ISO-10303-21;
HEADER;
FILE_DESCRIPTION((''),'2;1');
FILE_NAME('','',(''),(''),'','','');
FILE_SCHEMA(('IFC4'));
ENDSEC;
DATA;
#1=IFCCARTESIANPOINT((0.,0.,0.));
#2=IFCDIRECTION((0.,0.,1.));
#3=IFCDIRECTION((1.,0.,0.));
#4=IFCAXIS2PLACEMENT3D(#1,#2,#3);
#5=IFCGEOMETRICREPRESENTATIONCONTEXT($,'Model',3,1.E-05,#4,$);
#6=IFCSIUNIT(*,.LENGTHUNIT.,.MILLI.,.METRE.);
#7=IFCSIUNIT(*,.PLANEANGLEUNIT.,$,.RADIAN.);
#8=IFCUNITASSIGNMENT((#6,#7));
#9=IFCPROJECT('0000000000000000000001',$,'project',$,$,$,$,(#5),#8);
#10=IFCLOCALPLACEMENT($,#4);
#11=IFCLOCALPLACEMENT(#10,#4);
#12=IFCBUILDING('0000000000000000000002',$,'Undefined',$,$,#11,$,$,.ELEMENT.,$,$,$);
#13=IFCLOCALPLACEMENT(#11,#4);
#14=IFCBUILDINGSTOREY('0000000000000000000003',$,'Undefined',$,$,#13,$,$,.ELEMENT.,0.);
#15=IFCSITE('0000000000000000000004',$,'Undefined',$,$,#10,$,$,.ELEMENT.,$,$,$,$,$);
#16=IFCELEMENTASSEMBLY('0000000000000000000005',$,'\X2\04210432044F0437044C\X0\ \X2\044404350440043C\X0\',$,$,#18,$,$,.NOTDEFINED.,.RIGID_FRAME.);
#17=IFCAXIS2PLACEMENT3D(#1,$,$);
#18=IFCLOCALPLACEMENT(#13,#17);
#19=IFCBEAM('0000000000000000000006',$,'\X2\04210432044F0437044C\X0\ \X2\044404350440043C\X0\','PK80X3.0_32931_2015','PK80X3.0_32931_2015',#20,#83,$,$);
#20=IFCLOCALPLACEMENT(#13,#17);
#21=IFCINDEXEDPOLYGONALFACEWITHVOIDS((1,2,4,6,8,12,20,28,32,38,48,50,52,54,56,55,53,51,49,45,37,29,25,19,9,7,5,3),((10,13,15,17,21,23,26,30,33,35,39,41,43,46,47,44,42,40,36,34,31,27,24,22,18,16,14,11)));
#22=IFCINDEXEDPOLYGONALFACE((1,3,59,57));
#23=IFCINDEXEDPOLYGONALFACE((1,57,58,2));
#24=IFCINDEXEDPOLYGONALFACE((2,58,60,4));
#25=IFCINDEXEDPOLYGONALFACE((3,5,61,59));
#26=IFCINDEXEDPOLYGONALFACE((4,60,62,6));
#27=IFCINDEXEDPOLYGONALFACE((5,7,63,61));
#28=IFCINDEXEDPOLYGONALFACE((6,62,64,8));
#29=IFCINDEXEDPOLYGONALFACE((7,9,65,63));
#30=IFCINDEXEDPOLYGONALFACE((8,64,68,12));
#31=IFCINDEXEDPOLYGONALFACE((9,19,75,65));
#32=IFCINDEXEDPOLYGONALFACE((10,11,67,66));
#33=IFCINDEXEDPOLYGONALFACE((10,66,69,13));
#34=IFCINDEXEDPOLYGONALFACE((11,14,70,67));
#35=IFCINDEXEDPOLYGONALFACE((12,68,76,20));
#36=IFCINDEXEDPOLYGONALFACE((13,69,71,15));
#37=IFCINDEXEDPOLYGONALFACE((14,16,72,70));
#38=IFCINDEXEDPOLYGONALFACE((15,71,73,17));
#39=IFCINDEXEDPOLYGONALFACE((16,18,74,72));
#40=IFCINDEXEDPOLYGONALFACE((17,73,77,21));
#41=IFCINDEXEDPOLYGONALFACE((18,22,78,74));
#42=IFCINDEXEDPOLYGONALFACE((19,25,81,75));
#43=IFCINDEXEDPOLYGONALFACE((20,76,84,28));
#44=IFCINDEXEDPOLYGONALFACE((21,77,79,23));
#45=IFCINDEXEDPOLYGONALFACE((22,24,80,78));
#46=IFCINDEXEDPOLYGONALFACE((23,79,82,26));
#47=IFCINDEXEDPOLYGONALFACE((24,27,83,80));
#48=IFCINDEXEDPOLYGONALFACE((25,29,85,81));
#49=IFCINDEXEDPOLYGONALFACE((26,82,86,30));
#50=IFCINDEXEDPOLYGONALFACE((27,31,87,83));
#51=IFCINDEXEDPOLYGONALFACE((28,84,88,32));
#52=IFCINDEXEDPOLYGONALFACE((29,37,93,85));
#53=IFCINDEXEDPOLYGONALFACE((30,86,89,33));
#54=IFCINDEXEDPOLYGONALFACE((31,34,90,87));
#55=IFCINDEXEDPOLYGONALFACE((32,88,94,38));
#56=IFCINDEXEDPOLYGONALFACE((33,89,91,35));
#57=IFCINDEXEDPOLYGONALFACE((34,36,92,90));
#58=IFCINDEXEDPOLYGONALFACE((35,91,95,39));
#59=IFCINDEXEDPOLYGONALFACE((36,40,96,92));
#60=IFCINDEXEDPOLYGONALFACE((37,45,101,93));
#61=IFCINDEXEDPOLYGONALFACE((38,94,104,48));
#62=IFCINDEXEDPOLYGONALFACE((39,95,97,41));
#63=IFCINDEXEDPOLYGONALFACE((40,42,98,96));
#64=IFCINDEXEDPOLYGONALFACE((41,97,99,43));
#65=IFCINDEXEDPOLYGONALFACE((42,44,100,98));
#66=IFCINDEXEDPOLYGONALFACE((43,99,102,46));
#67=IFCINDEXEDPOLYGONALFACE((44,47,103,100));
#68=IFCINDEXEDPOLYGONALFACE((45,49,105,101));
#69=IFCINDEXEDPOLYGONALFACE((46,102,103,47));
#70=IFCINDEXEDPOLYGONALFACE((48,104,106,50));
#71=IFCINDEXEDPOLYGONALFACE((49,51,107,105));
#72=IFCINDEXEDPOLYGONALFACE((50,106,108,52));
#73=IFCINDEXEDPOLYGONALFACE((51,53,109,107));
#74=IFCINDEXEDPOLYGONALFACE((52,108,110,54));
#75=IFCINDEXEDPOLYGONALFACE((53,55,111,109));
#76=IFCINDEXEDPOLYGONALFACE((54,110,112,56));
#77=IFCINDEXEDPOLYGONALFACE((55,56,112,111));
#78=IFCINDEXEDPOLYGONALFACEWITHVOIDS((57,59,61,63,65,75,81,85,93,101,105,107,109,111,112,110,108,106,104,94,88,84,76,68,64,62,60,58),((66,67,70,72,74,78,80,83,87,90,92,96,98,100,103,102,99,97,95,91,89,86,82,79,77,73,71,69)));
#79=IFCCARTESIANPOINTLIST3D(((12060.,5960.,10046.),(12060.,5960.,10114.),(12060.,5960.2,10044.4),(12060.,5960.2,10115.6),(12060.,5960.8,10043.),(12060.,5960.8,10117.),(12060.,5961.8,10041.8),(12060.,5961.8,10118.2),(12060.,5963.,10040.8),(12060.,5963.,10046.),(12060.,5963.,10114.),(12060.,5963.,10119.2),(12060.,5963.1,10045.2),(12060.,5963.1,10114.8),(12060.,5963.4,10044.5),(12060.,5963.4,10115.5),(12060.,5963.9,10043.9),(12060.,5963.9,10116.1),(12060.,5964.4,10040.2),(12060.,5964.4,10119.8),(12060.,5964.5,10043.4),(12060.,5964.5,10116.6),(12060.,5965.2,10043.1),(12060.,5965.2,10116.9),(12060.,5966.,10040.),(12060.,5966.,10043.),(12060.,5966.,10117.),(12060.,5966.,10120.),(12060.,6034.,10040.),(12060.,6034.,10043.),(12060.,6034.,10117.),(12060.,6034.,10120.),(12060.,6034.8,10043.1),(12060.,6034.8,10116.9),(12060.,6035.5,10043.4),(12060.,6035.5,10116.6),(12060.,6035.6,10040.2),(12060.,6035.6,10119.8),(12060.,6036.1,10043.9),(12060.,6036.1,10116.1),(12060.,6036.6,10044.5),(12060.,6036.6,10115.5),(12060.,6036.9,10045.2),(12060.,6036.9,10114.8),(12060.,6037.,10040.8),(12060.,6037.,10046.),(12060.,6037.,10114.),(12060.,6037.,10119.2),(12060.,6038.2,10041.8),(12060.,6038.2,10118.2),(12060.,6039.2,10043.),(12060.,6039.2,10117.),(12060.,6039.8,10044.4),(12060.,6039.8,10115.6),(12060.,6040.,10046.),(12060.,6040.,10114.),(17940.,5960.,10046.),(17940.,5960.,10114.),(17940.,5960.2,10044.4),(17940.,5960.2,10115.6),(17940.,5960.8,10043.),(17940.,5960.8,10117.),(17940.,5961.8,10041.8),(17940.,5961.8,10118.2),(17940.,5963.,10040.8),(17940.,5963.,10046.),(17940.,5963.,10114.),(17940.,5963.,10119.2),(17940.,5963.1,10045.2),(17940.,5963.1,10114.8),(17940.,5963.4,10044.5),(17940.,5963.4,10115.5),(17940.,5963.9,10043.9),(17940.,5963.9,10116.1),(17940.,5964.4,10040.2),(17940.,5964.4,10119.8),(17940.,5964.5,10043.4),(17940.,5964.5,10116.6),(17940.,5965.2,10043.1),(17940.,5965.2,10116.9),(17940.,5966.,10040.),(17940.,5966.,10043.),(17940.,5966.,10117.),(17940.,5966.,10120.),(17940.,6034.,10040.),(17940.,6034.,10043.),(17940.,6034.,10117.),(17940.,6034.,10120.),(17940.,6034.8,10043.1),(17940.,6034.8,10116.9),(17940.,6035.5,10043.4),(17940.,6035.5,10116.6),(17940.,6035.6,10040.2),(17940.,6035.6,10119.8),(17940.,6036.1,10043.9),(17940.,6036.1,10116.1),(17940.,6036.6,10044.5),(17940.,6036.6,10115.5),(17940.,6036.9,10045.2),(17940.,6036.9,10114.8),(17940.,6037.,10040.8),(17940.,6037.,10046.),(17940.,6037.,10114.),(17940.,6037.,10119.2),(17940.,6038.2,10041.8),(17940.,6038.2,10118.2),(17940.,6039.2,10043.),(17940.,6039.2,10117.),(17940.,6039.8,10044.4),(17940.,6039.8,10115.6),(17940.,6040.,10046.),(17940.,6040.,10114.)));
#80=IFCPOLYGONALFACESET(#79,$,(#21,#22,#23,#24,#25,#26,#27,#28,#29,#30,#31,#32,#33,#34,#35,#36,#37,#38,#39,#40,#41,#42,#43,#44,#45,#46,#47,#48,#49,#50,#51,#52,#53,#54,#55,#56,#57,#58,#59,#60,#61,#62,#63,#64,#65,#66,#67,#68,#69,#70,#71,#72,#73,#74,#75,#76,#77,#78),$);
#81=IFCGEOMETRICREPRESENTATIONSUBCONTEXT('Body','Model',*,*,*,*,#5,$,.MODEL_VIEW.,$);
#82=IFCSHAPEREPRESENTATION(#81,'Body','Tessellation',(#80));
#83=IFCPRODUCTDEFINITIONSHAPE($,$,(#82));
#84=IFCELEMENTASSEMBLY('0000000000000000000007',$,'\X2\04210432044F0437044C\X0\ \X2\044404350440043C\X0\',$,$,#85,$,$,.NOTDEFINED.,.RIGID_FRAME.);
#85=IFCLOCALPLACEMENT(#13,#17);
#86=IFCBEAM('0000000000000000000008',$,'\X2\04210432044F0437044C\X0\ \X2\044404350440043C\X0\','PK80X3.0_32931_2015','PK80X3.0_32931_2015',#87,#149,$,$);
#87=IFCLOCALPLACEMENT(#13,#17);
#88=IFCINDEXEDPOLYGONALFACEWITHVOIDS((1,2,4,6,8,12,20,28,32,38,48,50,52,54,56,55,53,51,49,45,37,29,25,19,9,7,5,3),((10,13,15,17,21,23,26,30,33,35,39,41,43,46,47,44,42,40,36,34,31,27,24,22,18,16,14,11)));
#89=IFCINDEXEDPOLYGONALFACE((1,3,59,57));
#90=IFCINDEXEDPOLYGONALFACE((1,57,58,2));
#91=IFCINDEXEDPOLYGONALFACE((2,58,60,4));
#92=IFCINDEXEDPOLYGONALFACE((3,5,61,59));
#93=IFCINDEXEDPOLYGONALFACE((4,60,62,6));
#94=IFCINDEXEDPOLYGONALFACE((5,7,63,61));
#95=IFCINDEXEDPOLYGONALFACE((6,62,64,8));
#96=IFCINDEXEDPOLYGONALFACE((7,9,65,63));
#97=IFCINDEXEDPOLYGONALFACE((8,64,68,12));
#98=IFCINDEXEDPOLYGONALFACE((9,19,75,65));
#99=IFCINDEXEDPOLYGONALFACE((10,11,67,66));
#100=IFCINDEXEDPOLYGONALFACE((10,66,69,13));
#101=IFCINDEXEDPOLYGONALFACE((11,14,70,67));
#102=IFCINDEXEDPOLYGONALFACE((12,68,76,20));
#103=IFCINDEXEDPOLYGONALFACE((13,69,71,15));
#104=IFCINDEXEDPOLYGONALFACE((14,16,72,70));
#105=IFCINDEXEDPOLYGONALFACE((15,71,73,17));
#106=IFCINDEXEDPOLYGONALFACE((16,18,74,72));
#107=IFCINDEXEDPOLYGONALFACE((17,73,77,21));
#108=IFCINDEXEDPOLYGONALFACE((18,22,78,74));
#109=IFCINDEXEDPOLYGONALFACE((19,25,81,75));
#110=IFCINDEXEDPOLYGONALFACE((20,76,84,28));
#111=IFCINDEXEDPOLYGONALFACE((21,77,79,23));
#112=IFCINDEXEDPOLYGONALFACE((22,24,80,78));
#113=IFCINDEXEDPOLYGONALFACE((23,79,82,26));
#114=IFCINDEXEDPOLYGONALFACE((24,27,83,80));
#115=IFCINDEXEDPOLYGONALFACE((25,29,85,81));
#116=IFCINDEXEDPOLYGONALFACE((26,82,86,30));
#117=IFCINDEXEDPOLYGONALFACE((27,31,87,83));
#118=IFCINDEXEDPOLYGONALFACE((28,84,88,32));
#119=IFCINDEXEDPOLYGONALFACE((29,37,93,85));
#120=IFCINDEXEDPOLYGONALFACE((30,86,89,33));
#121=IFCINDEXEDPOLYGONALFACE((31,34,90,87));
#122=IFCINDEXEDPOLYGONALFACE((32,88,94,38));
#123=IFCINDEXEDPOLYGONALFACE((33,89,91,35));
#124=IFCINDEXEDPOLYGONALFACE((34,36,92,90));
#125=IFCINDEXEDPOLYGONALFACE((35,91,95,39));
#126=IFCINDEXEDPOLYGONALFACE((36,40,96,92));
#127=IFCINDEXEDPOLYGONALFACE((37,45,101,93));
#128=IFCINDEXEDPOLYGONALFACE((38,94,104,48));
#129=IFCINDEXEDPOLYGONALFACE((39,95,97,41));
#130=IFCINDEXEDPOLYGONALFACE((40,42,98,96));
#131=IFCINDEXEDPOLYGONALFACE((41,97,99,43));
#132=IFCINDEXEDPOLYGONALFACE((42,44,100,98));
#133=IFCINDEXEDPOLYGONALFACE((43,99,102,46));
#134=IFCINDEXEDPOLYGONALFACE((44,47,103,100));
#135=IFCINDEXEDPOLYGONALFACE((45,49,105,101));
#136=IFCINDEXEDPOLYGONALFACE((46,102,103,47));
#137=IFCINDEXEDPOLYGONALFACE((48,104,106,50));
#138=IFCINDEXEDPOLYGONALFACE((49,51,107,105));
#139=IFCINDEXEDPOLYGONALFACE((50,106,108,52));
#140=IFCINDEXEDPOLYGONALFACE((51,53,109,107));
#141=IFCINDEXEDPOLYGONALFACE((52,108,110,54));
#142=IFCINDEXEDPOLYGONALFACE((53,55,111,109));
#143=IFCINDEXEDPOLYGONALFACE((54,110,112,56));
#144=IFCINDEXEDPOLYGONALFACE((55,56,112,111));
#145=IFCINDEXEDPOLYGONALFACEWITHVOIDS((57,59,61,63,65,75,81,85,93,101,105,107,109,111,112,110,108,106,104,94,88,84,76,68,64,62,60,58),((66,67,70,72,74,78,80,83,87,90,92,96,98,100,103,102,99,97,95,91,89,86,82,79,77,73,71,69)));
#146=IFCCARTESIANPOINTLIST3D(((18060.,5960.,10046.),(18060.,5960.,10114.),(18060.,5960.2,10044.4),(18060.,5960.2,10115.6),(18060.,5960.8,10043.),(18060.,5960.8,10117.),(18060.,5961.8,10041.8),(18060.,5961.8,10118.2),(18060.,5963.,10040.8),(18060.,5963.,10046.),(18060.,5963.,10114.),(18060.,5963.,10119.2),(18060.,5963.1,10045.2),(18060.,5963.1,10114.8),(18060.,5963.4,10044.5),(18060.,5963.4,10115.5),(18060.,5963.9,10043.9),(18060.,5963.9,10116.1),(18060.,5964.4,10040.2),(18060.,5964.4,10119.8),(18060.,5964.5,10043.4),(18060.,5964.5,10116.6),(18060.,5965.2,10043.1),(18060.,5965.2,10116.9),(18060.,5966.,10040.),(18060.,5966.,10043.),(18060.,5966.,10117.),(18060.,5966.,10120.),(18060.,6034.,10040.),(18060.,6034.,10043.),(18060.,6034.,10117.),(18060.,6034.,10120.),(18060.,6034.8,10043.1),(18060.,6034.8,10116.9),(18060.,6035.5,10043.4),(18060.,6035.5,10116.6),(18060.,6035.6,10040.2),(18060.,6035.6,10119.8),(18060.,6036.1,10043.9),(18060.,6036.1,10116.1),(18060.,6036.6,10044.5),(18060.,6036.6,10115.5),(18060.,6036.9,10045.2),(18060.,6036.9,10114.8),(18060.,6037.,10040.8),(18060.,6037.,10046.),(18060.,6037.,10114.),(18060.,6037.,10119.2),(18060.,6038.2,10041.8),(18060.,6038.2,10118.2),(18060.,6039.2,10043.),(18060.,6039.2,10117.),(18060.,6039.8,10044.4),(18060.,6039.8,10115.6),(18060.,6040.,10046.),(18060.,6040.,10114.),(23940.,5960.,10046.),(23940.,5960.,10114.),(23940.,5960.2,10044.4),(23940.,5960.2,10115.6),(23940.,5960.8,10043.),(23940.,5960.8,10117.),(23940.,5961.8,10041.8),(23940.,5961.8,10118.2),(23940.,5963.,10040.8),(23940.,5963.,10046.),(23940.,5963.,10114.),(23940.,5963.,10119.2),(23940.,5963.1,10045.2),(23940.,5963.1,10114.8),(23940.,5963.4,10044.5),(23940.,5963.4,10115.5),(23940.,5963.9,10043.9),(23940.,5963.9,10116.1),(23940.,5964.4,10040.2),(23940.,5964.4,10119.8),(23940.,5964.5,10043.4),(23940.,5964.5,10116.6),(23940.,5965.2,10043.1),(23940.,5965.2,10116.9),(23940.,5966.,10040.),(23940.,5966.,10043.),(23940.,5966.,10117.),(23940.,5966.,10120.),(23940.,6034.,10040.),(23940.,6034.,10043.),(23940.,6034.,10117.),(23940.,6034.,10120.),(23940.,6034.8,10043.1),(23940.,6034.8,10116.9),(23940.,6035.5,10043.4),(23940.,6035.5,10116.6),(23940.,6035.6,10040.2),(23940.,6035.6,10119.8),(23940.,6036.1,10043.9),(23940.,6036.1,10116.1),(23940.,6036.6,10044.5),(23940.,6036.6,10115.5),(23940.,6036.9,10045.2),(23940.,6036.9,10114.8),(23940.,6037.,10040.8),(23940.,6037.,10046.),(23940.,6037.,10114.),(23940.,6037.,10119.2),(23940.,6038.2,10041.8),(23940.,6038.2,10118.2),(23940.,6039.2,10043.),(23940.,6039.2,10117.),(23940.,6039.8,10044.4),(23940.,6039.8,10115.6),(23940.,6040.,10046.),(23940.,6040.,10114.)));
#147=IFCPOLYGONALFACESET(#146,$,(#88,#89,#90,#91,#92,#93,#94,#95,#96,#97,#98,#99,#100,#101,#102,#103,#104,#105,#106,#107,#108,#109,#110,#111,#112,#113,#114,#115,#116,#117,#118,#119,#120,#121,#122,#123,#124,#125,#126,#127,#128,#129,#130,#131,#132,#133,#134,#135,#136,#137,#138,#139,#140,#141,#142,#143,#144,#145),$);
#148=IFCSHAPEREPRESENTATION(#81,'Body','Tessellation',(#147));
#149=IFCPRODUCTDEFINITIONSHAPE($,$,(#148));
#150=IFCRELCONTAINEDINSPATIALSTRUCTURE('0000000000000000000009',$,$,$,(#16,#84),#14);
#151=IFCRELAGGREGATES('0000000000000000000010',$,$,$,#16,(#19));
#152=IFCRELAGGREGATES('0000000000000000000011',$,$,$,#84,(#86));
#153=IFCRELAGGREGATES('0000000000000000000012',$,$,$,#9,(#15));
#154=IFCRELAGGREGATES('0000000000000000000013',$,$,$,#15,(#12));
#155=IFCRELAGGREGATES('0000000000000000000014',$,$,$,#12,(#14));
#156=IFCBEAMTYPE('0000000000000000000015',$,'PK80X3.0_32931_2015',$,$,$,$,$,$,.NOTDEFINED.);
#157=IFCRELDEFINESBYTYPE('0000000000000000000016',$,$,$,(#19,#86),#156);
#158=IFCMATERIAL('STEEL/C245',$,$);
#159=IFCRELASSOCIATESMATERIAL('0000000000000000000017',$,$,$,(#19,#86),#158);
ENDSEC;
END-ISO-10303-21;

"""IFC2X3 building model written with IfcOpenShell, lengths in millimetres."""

from ifc_helpers import new_model, si_unit, frame, origin_with_axes, origin_2d_with_axis, place, context, subcontext, project, spatial, hollow_rectangle, extrude, material, type_object, element, aggregate, save


model = new_model("IFC2X3")

# Units and contexts
model_context = context("Model", 3, precision=1e-05, world=origin_with_axes())
body_context = subcontext(model_context, "Body", "Model", "MODEL_VIEW")
ifc_project = project(units=[si_unit("LENGTHUNIT", "METRE", prefix="MILLI"), si_unit("PLANEANGLEUNIT", "RADIAN")], contexts=[model_context])

# Site, building, storey
site_placement = place(None, origin_with_axes())
site = spatial("IfcSite", under=ifc_project, at=site_placement, Name="Undefined", CompositionType="ELEMENT")
building_placement = place(site_placement, origin_with_axes())
building = spatial("IfcBuilding", under=site, at=building_placement, Name="Undefined", CompositionType="ELEMENT")
storey_placement = place(building_placement, origin_with_axes())
storey = spatial("IfcBuildingStorey", under=building, at=storey_placement, Name="Undefined", CompositionType="ELEMENT", Elevation=0.0)

# Shared definitions
ifc_material_1 = material(Name="STEEL/C245")

# Element assemblies, beams
assembly_1_placement = place(storey_placement, origin_with_axes())
assembly_1 = element("IfcElementAssembly", 1, at=assembly_1_placement, inside=storey, Name="Связь ферм", AssemblyPlace="NOTDEFINED", PredefinedType="RIGID_FRAME")
beam_type_1 = type_object("IfcBeamType", Name="PK80X3.0_32931_2015", PredefinedType="NOTDEFINED")
beam_1_placement = place(assembly_1_placement, frame((12060.0, 6000.0, 10080.0), z_axis=(0.0, 0.0, 1.0), x_axis=(1.0, 0.0, 0.0)))
beam_1 = element("IfcBeam", 2, at=beam_1_placement, type_object=beam_type_1, material=ifc_material_1, Name="Связь ферм", Description="PK80X3.0_32931_2015", ObjectType="PK80X3.0_32931_2015", context=body_context, shape_type="SweptSolid", body=[
    extrude(hollow_rectangle(XDim=80.0, YDim=80.0, WallThickness=3.0, InnerFilletRadius=3.0, OuterFilletRadius=6.0, at=origin_2d_with_axis()), frame((5880.0, 0.0, 0.0), z_axis=(-1.0, 0.0, 0.0), x_axis=(0.0, -1.0, 0.0)), (0.0, 0.0, 1.0), 5880.0),
])
aggregate(assembly_1, [beam_1])
assembly_2_placement = place(storey_placement, origin_with_axes())
assembly_2 = element("IfcElementAssembly", 3, at=assembly_2_placement, inside=storey, Name="Связь ферм", AssemblyPlace="NOTDEFINED", PredefinedType="RIGID_FRAME")
beam_2_placement = place(assembly_2_placement, frame((18060.0, 6000.0, 10080.0), z_axis=(0.0, 0.0, 1.0), x_axis=(1.0, 0.0, 0.0)))
beam_2 = element("IfcBeam", 4, at=beam_2_placement, type_object=beam_type_1, material=ifc_material_1, Name="Связь ферм", Description="PK80X3.0_32931_2015", ObjectType="PK80X3.0_32931_2015", context=body_context, shape_type="SweptSolid", body=[
    extrude(hollow_rectangle(XDim=80.0, YDim=80.0, WallThickness=3.0, InnerFilletRadius=3.0, OuterFilletRadius=6.0, at=origin_2d_with_axis()), frame((5880.0, 0.0, 0.0), z_axis=(-1.0, 0.0, 0.0), x_axis=(0.0, -1.0, 0.0)), (0.0, 0.0, 1.0), 5880.0),
])
aggregate(assembly_2, [beam_2])

save(model, "model.ifc")
